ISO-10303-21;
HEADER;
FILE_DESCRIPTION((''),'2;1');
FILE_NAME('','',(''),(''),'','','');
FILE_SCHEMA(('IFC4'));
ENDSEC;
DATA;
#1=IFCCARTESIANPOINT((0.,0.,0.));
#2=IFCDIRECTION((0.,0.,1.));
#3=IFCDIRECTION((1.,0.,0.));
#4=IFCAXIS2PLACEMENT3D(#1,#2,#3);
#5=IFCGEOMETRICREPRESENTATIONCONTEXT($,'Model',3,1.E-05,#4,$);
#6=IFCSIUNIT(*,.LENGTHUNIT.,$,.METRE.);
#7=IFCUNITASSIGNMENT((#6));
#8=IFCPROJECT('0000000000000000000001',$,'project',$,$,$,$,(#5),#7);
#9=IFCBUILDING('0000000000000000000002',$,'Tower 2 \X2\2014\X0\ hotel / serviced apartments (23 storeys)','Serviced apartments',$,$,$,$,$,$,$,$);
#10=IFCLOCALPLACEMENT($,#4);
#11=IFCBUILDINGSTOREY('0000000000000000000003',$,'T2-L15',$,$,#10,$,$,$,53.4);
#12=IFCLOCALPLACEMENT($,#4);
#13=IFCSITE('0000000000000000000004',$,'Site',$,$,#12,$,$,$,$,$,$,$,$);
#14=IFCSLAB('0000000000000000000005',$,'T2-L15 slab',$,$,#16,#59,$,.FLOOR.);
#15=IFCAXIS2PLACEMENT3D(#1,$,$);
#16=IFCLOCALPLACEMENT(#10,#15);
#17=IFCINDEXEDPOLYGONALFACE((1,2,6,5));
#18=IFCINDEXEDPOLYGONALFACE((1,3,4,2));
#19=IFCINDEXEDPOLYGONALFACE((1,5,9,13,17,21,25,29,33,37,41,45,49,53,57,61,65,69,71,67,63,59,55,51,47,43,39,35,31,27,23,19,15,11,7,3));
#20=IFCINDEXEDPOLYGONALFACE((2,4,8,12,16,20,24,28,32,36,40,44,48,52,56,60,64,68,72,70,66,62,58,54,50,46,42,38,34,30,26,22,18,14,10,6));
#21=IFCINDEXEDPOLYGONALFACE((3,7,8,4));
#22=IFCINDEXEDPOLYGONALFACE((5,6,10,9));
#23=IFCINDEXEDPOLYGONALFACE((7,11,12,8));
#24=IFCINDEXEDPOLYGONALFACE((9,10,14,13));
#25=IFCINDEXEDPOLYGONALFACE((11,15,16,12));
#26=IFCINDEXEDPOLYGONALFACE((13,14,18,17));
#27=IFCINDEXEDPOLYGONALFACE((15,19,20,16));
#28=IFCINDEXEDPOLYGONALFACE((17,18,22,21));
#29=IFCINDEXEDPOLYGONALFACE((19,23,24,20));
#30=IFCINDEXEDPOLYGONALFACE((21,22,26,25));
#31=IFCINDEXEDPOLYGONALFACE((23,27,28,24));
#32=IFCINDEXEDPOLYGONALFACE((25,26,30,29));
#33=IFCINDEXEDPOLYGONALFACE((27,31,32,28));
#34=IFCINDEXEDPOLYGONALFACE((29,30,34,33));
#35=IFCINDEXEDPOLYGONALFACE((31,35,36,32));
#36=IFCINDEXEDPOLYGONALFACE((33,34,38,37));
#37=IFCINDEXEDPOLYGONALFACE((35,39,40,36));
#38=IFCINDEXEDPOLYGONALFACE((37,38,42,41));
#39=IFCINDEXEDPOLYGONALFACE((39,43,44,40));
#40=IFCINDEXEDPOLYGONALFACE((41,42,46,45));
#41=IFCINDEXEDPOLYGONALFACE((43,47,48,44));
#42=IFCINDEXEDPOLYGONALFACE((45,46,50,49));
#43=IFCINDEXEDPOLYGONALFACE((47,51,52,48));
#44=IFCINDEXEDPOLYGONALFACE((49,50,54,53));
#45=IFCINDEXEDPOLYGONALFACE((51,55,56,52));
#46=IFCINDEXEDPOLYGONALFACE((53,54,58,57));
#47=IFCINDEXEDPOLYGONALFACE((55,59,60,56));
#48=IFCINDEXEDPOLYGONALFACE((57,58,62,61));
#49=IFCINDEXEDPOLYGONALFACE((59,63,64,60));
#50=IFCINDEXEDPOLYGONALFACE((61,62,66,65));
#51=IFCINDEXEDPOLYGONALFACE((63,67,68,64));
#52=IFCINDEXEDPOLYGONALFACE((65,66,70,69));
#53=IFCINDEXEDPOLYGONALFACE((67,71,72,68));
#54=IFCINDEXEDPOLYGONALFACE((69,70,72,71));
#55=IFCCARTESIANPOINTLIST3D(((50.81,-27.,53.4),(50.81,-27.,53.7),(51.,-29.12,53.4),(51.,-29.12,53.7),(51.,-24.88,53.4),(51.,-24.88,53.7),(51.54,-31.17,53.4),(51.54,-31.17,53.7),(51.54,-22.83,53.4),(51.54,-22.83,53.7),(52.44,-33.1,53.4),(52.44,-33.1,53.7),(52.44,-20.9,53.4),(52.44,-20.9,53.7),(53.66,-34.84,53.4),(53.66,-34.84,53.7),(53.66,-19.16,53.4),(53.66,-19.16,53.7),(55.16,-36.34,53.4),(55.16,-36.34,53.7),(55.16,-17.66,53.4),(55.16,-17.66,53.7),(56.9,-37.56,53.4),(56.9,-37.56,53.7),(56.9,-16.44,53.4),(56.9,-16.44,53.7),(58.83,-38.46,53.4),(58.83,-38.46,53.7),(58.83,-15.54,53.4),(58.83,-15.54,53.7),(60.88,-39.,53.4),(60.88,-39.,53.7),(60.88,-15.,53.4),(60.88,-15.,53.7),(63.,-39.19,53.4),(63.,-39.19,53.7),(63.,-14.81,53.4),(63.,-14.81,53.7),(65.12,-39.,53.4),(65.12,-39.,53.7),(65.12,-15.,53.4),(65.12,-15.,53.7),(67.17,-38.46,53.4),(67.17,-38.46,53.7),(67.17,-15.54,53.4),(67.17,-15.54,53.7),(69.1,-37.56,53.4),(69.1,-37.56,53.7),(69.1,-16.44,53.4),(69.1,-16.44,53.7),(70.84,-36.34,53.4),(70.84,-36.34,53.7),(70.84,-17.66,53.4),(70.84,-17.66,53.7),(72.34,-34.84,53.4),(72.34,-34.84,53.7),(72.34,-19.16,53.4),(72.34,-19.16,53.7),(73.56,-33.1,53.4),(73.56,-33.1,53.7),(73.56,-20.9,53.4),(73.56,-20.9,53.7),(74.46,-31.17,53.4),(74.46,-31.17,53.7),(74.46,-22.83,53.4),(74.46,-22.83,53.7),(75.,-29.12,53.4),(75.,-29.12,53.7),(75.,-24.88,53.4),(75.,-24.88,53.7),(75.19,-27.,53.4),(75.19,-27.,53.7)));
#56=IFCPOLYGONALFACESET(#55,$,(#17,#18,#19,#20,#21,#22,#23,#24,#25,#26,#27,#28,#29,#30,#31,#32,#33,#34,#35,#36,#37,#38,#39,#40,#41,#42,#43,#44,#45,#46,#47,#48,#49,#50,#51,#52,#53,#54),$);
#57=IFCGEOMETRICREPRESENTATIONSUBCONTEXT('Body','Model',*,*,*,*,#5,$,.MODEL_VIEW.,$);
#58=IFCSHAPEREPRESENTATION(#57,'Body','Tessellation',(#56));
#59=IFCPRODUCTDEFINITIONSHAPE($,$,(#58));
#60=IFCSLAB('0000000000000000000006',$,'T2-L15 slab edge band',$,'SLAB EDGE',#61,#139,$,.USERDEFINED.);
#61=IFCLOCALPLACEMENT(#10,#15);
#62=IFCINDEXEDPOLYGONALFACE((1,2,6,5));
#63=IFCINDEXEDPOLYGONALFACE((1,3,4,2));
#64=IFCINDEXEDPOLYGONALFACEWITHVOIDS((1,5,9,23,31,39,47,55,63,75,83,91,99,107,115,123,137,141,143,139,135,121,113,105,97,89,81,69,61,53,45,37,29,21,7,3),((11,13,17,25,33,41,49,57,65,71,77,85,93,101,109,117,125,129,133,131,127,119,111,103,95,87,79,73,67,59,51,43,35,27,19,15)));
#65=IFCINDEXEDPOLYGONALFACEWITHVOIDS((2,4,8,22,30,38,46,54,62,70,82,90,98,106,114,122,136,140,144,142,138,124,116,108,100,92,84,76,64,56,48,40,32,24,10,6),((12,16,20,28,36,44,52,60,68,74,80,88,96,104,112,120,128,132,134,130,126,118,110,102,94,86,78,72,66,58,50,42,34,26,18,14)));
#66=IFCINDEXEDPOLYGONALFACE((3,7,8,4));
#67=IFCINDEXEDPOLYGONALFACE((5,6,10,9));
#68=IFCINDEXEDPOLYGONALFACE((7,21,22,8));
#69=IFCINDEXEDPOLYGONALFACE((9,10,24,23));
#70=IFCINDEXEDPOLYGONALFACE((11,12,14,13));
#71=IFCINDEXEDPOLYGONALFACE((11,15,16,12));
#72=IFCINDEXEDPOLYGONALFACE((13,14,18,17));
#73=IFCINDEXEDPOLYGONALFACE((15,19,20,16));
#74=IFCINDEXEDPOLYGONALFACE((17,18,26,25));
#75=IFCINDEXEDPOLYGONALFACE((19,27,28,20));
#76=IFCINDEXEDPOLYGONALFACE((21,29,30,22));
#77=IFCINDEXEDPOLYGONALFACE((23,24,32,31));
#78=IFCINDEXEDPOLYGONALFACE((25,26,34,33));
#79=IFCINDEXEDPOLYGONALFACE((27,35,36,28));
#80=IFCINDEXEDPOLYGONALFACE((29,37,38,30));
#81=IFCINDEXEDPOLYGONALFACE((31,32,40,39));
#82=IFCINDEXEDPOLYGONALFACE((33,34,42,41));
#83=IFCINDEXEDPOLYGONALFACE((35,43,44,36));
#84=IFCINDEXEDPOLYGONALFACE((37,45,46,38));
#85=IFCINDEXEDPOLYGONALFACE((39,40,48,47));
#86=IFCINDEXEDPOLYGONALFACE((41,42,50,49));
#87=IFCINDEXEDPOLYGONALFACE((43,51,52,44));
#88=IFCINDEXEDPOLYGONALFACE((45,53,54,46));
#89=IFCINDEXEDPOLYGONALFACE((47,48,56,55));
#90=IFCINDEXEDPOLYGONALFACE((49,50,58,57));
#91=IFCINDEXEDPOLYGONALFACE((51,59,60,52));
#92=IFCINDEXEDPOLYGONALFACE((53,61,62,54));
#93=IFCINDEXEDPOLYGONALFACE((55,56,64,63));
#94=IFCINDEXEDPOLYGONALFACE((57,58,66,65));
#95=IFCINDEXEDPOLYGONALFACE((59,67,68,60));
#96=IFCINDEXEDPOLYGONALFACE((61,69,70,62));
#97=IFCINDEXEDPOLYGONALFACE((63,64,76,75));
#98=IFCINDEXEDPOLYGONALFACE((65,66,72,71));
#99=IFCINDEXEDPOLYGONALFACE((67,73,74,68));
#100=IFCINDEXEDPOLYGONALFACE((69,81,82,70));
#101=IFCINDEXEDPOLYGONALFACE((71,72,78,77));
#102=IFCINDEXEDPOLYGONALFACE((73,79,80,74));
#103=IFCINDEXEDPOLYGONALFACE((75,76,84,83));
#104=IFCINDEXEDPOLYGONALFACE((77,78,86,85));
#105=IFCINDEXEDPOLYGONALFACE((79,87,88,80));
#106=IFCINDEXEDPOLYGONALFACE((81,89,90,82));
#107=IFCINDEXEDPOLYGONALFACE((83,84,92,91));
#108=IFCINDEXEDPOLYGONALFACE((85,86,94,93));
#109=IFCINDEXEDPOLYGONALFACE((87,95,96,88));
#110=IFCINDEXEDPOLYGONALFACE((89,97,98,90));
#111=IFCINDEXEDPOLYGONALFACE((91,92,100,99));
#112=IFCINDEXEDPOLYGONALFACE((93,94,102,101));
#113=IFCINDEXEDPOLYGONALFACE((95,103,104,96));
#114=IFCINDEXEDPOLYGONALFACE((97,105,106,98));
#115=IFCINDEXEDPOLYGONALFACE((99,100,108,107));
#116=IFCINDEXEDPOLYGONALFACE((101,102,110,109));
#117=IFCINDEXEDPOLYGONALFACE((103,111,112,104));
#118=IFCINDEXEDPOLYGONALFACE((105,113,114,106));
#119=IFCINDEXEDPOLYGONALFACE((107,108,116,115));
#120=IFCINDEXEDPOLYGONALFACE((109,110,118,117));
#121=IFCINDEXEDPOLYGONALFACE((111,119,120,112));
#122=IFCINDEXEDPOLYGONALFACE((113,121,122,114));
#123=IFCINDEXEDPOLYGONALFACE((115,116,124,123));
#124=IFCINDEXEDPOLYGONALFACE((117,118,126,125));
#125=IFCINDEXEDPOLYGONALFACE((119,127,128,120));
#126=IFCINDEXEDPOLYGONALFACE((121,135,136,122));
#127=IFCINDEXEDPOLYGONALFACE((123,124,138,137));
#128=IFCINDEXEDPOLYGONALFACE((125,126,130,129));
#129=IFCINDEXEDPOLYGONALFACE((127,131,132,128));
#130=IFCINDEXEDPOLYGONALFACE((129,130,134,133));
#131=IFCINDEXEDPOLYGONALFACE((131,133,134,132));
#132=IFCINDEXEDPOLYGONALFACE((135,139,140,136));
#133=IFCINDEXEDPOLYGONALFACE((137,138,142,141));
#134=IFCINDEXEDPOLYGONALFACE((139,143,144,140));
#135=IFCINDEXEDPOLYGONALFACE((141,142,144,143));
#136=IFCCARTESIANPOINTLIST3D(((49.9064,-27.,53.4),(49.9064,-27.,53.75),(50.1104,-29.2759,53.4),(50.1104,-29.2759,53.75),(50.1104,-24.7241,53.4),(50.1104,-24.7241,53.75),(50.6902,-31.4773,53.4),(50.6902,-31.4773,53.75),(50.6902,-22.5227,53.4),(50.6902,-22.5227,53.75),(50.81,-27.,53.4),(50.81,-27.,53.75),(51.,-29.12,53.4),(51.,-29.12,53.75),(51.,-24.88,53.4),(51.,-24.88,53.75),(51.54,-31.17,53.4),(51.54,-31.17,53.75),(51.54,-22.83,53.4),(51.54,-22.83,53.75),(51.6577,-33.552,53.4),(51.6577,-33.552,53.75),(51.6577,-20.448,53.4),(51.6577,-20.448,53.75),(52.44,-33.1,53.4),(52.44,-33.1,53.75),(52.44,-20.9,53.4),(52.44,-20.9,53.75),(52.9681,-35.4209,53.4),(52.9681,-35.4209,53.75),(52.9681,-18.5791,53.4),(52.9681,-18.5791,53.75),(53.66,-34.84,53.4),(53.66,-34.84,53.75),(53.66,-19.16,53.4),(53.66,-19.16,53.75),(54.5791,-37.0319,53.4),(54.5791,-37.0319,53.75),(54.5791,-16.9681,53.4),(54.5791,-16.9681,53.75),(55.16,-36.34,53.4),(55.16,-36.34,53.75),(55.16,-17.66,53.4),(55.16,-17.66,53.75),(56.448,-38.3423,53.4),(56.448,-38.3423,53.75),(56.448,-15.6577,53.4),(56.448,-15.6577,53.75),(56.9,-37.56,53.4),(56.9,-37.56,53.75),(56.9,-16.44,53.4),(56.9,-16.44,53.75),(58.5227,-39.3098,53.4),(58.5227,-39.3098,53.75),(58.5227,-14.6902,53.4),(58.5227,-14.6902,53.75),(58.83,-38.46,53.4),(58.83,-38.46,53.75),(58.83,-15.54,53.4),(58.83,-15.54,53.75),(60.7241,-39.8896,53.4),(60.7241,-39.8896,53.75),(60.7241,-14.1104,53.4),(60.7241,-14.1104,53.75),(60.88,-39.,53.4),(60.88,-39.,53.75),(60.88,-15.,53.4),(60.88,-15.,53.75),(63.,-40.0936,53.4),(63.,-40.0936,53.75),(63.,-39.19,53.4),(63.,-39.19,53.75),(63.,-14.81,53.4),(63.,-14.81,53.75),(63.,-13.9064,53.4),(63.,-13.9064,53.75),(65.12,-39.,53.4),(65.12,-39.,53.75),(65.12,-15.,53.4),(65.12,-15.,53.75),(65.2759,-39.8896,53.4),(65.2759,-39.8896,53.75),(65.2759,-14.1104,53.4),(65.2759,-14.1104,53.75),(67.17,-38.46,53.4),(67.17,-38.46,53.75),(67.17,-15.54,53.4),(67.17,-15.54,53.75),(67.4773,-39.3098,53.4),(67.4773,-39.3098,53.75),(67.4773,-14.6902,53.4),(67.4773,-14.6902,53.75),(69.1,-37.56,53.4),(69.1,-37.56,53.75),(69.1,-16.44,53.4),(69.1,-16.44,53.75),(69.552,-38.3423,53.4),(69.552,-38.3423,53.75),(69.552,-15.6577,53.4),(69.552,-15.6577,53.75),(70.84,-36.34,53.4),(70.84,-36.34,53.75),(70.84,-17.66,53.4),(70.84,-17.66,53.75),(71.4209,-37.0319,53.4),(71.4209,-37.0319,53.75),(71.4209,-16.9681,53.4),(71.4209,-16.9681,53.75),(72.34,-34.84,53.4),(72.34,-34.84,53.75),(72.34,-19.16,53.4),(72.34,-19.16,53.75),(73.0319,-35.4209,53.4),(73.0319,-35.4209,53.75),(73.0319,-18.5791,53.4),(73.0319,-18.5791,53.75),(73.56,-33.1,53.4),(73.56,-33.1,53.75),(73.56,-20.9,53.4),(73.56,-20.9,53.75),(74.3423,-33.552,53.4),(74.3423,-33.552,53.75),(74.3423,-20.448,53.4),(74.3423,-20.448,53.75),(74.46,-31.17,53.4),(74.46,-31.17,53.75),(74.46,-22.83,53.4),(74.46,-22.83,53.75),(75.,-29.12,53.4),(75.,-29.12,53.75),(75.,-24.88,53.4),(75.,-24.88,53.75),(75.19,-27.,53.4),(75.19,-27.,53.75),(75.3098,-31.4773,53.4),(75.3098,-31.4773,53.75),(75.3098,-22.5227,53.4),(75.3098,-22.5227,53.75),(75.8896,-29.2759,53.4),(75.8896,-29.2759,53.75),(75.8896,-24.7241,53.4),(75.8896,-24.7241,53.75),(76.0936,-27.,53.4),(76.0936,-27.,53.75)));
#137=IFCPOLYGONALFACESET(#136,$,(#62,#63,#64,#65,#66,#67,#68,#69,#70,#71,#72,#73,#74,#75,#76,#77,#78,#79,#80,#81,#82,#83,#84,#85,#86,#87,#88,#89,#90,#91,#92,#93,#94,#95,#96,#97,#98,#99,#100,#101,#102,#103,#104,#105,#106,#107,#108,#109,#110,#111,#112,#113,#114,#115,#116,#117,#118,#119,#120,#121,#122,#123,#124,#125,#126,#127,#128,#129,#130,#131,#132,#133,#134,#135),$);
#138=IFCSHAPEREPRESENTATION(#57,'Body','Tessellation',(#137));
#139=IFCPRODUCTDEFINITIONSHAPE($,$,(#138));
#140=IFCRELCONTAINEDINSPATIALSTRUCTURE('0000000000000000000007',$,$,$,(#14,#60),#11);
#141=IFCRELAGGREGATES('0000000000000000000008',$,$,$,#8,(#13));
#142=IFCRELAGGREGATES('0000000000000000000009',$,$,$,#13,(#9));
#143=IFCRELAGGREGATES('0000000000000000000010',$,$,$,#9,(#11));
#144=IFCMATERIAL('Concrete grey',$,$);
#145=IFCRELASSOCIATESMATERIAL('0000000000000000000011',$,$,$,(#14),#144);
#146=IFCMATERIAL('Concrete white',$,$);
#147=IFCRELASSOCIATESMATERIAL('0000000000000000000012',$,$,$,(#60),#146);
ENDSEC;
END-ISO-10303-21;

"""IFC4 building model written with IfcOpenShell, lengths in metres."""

from ifc_helpers import new_model, si_unit, frame, origin_with_axes, place, context, subcontext, project, spatial, polyline, outline, extrude, material, element, save


model = new_model("IFC4")

# Units and contexts
model_context = context("Model", 3, precision=1e-05, world=origin_with_axes())
body_context = subcontext(model_context, "Body", "Model", "MODEL_VIEW")
ifc_project = project(units=[si_unit("LENGTHUNIT", "METRE")], contexts=[model_context])

# Site, building, storey
site_placement = place(None, origin_with_axes())
site = spatial("IfcSite", under=ifc_project, at=site_placement, Name="Site")
building = spatial("IfcBuilding", under=site, Name="Tower 2 — hotel / serviced apartments (23 storeys)", Description="Serviced apartments")
storey_placement = place(None, origin_with_axes())
storey = spatial("IfcBuildingStorey", under=building, at=storey_placement, Name="T2-L15", Elevation=53.4)

# Slab
ifc_material_1 = material(Name="Concrete grey")
slab_1_placement = place(storey_placement, origin_with_axes())
element("IfcSlab", 1, at=slab_1_placement, inside=storey, material=ifc_material_1, Name="T2-L15 slab", PredefinedType="FLOOR", context=body_context, shape_type="SweptSolid", body=[
    extrude(outline(polyline([(75.19, -27.0), (75.0, -24.88), (74.46, -22.83), (73.56, -20.9), (72.34, -19.16), (70.84, -17.66), (69.1, -16.44), (67.17, -15.54), (65.12, -15.0), (63.0, -14.81), (60.88, -15.0), (58.83, -15.54), (56.9, -16.44), (55.16, -17.66), (53.66, -19.16), (52.44, -20.9), (51.54, -22.83), (51.0, -24.88), (50.81, -27.0), (51.0, -29.12), (51.54, -31.17), (52.44, -33.1), (53.66, -34.84), (55.16, -36.34), (56.9, -37.56), (58.83, -38.46), (60.88, -39.0), (63.0, -39.19), (65.12, -39.0), (67.17, -38.46), (69.1, -37.56), (70.84, -36.34), (72.34, -34.84), (73.56, -33.1), (74.46, -31.17), (75.0, -29.12), (75.19, -27.0)])), frame((0.0, 0.0, 53.4), z_axis=(0.0, 0.0, 1.0), x_axis=(1.0, 0.0, 0.0)), (0.0, 0.0, 1.0), 0.3),
])

# Slab
ifc_material_2 = material(Name="Concrete white")
slab_2_placement = place(storey_placement, origin_with_axes())
element("IfcSlab", 2, at=slab_2_placement, inside=storey, material=ifc_material_2, Name="T2-L15 slab edge band", ObjectType="SLAB EDGE", PredefinedType="USERDEFINED", context=body_context, shape_type="SweptSolid", body=[
    extrude(outline(polyline([(76.0936, -27.0), (75.8896, -24.7241), (75.3098, -22.5227), (74.3423, -20.448), (73.0319, -18.5791), (71.4209, -16.9681), (69.552, -15.6577), (67.4773, -14.6902), (65.2759, -14.1104), (63.0, -13.9064), (60.7241, -14.1104), (58.5227, -14.6902), (56.448, -15.6577), (54.5791, -16.9681), (52.9681, -18.5791), (51.6577, -20.448), (50.6902, -22.5227), (50.1104, -24.7241), (49.9064, -27.0), (50.1104, -29.2759), (50.6902, -31.4773), (51.6577, -33.552), (52.9681, -35.4209), (54.5791, -37.0319), (56.448, -38.3423), (58.5227, -39.3098), (60.7241, -39.8896), (63.0, -40.0936), (65.2759, -39.8896), (67.4773, -39.3098), (69.552, -38.3423), (71.4209, -37.0319), (73.0319, -35.4209), (74.3423, -33.552), (75.3098, -31.4773), (75.8896, -29.2759), (76.0936, -27.0)]), holes=[polyline([(75.19, -27.0), (75.0, -24.88), (74.46, -22.83), (73.56, -20.9), (72.34, -19.16), (70.84, -17.66), (69.1, -16.44), (67.17, -15.54), (65.12, -15.0), (63.0, -14.81), (60.88, -15.0), (58.83, -15.54), (56.9, -16.44), (55.16, -17.66), (53.66, -19.16), (52.44, -20.9), (51.54, -22.83), (51.0, -24.88), (50.81, -27.0), (51.0, -29.12), (51.54, -31.17), (52.44, -33.1), (53.66, -34.84), (55.16, -36.34), (56.9, -37.56), (58.83, -38.46), (60.88, -39.0), (63.0, -39.19), (65.12, -39.0), (67.17, -38.46), (69.1, -37.56), (70.84, -36.34), (72.34, -34.84), (73.56, -33.1), (74.46, -31.17), (75.0, -29.12), (75.19, -27.0)])]), frame((0.0, 0.0, 53.4), z_axis=(0.0, 0.0, 1.0), x_axis=(1.0, 0.0, 0.0)), (0.0, 0.0, 1.0), 0.35),
])

save(model, "model.ifc")
